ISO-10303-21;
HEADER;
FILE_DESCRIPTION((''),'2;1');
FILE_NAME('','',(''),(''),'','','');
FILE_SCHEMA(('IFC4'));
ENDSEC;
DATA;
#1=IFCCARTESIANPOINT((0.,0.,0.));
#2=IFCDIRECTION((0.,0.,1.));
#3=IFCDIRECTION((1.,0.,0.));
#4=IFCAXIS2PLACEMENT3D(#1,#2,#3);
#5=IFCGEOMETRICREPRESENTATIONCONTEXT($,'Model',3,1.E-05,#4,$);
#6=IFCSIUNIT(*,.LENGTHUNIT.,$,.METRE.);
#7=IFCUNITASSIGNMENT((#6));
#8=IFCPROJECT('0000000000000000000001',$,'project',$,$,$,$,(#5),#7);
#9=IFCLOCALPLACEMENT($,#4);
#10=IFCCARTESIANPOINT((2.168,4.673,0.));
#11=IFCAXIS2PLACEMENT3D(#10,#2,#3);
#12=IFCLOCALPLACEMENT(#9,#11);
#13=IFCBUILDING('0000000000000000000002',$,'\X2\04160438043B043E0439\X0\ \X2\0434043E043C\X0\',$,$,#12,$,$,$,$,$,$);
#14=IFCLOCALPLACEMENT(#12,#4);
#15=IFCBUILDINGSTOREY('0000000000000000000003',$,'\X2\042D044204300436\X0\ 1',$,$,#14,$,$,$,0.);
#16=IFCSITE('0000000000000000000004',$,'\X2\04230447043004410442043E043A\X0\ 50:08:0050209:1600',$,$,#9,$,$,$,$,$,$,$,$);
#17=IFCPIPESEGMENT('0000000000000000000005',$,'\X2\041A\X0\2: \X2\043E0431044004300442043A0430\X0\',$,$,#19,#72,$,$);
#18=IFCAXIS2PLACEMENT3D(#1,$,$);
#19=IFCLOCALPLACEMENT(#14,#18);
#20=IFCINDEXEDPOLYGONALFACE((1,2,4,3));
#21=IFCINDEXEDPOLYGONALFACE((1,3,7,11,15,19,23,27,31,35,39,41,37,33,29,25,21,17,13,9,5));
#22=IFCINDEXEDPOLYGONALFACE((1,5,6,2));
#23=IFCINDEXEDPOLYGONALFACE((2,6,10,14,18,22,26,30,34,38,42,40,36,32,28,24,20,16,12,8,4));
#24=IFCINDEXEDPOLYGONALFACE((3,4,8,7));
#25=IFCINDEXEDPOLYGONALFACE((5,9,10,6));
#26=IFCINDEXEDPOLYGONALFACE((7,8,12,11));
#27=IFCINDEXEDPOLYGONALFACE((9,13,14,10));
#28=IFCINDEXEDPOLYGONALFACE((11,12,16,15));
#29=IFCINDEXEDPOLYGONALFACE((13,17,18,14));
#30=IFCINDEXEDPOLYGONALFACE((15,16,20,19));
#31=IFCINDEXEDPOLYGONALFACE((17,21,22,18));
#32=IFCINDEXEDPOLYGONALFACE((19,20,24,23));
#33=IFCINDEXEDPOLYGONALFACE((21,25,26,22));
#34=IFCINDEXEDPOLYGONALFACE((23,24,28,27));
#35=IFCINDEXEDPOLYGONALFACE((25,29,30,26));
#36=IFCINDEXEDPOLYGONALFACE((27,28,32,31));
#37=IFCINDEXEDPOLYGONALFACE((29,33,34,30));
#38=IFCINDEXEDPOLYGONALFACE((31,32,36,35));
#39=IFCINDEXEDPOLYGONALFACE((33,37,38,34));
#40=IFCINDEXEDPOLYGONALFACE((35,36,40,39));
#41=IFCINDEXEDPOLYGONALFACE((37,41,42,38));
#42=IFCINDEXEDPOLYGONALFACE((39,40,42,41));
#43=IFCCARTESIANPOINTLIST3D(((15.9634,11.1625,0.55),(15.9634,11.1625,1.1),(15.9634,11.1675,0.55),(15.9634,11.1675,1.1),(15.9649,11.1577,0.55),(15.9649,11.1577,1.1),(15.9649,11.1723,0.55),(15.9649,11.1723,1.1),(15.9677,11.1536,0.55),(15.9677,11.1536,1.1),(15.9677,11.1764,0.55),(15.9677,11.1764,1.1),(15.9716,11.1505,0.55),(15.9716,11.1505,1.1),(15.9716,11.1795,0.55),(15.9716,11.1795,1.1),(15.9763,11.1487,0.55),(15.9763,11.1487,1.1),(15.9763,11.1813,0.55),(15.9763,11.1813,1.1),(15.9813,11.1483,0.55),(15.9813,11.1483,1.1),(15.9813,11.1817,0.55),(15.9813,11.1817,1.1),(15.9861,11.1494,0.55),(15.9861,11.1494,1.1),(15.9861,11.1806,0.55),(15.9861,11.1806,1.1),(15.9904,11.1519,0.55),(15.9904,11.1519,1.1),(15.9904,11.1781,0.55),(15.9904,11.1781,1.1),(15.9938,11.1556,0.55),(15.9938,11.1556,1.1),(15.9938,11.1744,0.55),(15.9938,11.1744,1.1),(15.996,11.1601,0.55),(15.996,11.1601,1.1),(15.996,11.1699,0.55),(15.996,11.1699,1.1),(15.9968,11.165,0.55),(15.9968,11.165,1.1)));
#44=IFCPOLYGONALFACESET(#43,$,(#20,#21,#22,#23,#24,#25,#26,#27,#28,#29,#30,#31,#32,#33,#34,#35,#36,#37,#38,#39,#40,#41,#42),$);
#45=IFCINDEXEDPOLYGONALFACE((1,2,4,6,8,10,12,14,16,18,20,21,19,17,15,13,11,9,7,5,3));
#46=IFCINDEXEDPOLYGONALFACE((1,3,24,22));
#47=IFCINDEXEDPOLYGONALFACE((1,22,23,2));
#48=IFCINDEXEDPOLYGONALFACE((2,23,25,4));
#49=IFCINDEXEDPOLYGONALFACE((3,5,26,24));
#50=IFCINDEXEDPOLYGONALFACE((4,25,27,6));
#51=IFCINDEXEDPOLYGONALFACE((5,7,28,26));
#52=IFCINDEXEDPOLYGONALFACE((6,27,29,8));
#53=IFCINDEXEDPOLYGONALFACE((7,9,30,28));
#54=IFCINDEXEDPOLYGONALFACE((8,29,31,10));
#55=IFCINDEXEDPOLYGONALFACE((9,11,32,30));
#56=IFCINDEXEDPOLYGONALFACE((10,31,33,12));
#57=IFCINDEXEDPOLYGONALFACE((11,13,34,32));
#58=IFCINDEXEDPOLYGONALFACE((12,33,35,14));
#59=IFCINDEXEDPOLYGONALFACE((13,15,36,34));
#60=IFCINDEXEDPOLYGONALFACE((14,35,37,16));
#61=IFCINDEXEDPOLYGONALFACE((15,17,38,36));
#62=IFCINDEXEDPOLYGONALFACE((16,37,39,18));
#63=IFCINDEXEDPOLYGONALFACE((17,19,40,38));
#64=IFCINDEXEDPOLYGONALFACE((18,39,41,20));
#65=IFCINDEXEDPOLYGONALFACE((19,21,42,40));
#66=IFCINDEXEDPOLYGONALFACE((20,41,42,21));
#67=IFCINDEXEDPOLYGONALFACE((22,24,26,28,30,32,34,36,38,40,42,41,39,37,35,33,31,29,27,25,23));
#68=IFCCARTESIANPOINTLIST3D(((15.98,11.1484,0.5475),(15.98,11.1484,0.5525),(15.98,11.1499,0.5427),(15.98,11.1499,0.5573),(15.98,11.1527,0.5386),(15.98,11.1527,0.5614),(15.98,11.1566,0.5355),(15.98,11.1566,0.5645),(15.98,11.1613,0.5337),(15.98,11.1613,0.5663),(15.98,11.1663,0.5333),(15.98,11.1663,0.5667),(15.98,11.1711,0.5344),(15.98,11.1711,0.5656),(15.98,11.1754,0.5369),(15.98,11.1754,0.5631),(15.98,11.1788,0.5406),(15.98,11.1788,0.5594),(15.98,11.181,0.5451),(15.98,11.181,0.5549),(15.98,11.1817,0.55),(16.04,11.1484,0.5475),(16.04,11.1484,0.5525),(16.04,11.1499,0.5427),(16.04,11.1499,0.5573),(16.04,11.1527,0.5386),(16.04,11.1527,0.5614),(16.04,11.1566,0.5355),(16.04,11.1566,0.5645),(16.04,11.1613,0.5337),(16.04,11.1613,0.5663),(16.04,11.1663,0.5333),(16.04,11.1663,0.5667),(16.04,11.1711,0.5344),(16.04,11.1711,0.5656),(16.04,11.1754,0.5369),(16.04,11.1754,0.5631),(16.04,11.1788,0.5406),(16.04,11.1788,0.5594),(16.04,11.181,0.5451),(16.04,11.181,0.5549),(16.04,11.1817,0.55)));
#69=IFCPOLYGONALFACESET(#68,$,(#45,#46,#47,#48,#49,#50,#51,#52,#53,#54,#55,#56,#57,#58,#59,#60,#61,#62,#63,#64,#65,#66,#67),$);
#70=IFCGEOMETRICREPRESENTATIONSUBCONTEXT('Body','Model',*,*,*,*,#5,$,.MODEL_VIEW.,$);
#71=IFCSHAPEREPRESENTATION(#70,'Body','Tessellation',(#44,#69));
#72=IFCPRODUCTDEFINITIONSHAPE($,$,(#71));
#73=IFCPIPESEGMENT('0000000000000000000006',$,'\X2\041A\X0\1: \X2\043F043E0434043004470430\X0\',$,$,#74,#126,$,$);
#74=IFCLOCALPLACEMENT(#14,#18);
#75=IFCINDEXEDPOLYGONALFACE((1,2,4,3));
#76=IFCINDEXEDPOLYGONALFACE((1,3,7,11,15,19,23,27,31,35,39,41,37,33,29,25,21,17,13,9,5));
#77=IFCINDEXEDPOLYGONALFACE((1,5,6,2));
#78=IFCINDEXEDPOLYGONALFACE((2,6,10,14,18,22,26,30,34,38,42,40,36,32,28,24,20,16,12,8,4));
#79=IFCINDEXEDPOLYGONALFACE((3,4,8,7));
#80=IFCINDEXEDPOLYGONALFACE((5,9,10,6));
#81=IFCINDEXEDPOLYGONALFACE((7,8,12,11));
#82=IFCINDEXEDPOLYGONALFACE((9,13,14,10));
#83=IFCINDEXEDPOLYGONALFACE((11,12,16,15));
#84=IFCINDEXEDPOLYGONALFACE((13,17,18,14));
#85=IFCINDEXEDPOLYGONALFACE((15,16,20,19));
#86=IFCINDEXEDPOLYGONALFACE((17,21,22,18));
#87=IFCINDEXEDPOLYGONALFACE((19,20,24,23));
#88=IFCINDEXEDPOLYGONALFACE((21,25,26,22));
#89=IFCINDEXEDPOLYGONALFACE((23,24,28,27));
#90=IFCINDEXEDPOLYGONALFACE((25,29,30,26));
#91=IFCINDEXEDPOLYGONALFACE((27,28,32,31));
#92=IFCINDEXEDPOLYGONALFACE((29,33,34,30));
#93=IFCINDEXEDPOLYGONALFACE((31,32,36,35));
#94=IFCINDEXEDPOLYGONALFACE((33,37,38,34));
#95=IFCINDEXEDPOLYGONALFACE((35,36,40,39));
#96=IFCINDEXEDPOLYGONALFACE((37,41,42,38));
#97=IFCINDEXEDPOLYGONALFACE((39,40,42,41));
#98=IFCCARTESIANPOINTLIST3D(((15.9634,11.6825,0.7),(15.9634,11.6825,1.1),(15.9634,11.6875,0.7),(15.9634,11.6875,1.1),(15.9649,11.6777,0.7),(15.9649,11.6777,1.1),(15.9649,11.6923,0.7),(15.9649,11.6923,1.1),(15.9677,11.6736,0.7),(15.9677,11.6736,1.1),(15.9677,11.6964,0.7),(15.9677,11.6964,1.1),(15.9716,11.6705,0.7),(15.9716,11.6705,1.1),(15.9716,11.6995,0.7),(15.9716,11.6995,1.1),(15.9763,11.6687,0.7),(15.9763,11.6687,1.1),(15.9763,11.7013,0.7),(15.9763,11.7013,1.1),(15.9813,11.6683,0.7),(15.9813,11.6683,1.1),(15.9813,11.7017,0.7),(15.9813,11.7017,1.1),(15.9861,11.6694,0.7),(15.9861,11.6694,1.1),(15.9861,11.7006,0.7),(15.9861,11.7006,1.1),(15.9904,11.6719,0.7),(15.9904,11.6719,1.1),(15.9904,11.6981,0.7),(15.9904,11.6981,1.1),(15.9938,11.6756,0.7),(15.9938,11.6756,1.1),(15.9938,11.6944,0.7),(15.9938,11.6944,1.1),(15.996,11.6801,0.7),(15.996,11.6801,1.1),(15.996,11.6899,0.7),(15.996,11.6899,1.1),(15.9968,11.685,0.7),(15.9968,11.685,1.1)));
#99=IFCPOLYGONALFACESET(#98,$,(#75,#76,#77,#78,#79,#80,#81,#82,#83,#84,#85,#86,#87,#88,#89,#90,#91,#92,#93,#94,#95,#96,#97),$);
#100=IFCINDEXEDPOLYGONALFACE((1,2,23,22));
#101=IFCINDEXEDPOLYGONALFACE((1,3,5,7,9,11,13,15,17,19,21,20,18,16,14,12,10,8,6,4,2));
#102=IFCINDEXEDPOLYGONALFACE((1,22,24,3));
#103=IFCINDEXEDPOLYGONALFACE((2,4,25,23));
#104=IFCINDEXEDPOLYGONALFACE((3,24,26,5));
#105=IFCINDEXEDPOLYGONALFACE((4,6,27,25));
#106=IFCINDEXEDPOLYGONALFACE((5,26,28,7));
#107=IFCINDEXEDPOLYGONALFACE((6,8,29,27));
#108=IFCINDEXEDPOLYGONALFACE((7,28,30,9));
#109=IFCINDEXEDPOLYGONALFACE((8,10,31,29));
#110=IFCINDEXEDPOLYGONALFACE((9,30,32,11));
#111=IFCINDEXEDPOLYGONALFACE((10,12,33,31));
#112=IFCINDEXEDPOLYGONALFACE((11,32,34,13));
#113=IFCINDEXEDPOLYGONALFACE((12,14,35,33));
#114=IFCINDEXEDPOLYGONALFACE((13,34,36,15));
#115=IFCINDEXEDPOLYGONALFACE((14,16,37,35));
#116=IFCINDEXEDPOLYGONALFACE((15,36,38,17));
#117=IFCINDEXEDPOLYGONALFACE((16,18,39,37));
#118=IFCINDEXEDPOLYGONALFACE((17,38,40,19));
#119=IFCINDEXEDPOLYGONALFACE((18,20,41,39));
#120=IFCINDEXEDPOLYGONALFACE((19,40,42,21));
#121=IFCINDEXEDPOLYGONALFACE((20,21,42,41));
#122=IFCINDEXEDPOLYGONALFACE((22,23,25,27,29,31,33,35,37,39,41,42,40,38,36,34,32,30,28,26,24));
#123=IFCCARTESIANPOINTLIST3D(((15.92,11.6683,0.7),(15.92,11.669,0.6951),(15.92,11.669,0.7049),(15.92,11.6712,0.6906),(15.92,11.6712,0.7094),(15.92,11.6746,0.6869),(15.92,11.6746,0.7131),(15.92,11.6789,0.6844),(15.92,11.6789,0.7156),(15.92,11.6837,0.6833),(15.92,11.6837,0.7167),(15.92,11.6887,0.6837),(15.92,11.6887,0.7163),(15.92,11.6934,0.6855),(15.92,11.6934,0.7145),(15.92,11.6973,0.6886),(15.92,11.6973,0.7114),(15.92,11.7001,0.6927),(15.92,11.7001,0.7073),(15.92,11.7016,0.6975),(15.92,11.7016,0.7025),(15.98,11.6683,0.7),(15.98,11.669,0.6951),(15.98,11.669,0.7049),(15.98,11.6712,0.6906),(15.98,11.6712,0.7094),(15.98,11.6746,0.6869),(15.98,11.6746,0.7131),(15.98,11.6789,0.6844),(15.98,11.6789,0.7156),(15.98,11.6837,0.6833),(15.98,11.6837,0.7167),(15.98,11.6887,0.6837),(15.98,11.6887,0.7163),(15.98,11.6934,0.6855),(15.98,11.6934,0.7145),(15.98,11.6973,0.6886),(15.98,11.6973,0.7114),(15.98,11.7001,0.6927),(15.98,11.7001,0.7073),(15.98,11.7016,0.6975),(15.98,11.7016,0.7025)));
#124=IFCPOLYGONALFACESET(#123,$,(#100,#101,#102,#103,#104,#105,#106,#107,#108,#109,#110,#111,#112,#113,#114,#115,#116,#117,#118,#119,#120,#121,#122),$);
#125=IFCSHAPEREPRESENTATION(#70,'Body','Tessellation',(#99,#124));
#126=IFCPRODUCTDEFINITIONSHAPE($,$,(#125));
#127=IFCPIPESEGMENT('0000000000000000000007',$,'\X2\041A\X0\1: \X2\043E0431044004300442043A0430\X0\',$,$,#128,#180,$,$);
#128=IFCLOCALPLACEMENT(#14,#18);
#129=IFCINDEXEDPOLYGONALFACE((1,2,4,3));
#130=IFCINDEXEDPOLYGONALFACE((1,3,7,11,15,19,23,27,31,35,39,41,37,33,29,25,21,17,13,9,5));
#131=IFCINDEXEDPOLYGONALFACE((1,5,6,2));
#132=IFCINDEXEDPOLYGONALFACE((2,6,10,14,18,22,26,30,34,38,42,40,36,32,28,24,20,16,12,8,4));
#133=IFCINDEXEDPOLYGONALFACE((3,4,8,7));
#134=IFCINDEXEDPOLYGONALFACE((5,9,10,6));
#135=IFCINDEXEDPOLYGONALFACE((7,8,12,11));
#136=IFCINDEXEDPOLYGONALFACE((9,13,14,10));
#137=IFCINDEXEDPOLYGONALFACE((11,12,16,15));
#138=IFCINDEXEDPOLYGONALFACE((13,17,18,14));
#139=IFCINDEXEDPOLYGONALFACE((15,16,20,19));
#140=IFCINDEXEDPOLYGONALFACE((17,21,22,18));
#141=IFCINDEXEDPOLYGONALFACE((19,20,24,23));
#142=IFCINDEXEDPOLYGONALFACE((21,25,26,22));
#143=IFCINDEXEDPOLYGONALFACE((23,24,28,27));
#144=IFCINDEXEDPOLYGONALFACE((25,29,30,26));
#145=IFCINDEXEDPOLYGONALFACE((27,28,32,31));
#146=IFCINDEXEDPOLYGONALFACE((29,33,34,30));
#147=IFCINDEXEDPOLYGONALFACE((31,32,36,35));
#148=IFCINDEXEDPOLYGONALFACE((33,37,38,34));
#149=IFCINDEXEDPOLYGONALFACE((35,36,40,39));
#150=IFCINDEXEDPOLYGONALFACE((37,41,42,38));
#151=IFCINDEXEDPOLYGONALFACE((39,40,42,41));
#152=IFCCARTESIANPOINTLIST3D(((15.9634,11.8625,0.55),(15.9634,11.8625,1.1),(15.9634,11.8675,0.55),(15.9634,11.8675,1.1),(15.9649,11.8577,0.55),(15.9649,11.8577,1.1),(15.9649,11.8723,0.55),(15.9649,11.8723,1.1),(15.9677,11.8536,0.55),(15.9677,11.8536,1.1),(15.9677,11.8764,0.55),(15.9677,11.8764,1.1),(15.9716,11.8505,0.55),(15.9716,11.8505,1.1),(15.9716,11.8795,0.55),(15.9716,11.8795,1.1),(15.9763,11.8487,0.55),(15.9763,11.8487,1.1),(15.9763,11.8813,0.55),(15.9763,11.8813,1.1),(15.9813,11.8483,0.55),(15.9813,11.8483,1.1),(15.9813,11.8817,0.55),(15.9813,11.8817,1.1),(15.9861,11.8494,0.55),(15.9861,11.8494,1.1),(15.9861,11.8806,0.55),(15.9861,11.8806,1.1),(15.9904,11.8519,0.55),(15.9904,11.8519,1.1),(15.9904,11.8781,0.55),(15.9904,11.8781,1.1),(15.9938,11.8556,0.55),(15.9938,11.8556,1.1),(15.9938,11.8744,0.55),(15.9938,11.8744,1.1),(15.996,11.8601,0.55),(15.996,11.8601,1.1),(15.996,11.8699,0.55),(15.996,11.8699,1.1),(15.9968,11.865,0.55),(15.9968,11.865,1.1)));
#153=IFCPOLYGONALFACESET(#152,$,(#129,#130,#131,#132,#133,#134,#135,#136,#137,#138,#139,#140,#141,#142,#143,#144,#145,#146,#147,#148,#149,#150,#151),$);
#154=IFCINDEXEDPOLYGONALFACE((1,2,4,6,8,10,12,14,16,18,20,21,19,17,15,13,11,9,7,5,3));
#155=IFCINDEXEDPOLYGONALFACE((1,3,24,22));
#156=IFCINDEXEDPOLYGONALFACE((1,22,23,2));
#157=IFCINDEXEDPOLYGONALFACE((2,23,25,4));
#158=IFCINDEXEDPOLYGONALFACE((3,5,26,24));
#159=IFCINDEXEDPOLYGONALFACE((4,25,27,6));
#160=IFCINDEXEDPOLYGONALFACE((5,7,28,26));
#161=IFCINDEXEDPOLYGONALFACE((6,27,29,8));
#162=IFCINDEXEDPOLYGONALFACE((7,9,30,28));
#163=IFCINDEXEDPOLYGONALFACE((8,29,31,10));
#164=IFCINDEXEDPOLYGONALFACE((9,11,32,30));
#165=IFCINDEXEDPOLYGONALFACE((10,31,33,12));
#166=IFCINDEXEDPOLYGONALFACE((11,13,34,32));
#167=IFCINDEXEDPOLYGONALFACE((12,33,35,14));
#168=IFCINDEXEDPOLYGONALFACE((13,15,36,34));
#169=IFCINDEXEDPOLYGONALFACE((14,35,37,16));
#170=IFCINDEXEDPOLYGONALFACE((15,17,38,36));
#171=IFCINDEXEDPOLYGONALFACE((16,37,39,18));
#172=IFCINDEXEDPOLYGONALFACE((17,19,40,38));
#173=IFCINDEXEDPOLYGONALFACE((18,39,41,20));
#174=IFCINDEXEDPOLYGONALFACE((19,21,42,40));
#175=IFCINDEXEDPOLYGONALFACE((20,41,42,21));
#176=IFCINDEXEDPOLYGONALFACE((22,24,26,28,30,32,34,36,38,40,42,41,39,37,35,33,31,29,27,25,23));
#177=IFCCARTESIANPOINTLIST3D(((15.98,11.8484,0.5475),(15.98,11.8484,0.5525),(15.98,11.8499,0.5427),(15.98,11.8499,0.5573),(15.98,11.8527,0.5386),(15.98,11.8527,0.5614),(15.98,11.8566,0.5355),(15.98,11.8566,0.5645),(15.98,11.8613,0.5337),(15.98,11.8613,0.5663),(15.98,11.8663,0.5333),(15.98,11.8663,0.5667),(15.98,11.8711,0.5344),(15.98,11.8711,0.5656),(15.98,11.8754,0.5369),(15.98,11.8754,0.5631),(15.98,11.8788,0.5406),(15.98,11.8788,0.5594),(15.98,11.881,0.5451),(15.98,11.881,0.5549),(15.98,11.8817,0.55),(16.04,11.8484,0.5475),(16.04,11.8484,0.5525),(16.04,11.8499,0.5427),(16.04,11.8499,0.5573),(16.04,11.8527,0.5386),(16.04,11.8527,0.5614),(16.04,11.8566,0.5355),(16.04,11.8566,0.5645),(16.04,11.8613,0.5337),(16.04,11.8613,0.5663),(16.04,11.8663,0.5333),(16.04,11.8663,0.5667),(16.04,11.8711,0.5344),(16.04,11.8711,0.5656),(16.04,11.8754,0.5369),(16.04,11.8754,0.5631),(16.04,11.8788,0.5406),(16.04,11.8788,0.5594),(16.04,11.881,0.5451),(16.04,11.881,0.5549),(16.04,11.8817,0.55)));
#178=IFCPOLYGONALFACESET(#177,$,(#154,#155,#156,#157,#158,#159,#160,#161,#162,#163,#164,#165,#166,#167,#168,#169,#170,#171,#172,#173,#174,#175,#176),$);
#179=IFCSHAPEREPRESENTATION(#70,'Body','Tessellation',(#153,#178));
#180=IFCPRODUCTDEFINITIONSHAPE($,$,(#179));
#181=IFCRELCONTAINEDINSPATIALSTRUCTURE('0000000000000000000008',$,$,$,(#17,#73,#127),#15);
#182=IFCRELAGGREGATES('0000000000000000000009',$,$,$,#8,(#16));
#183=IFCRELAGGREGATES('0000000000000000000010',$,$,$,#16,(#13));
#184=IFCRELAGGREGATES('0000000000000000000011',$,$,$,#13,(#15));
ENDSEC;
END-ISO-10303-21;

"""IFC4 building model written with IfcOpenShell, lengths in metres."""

from ifc_helpers import new_model, si_unit, frame, origin_with_axes, origin_2d, place, context, subcontext, project, spatial, circle, extrude, element, save


model = new_model("IFC4")

# Units and contexts
model_context = context("Model", 3, precision=1e-05, world=origin_with_axes())
body_context = subcontext(model_context, "Body", "Model", "MODEL_VIEW")
ifc_project = project(units=[si_unit("LENGTHUNIT", "METRE")], contexts=[model_context])

# Site, building, storey
site_placement = place(None, origin_with_axes())
site = spatial("IfcSite", under=ifc_project, at=site_placement, Name="Участок 50:08:0050209:1600")
building_placement = place(site_placement, frame((2.168, 4.673, 0.0), z_axis=(0.0, 0.0, 1.0), x_axis=(1.0, 0.0, 0.0)))
building = spatial("IfcBuilding", under=site, at=building_placement, Name="Жилой дом")
storey_placement = place(building_placement, origin_with_axes())
storey = spatial("IfcBuildingStorey", under=building, at=storey_placement, Name="Этаж 1", Elevation=0.0)

# Pipe segments
pipe_segment_1_placement = place(storey_placement, origin_with_axes())
element("IfcPipeSegment", 1, at=pipe_segment_1_placement, inside=storey, Name="К2: обратка", context=body_context, shape_type="SweptSolid", body=[
    extrude(circle(Radius=0.0168, at=origin_2d()), frame((15.98, 11.165, 1.1), z_axis=(0.0, 0.0, -1.0), x_axis=(1.0, 0.0, 0.0)), (0.0, 0.0, 1.0), 0.55),
    extrude(circle(Radius=0.0168, at=origin_2d()), frame((15.98, 11.165, 0.55), z_axis=(1.0, 0.0, 0.0), x_axis=(0.0, 1.0, 0.0)), (0.0, 0.0, 1.0), 0.06),
])
pipe_segment_2_placement = place(storey_placement, origin_with_axes())
element("IfcPipeSegment", 2, at=pipe_segment_2_placement, inside=storey, Name="К1: подача", context=body_context, shape_type="SweptSolid", body=[
    extrude(circle(Radius=0.0168, at=origin_2d()), frame((15.98, 11.685, 1.1), z_axis=(0.0, 0.0, -1.0), x_axis=(1.0, 0.0, 0.0)), (0.0, 0.0, 1.0), 0.4),
    extrude(circle(Radius=0.0168, at=origin_2d()), frame((15.98, 11.685, 0.7), z_axis=(-1.0, 0.0, 0.0), x_axis=(0.0, -1.0, 0.0)), (0.0, 0.0, 1.0), 0.06),
])
pipe_segment_3_placement = place(storey_placement, origin_with_axes())
element("IfcPipeSegment", 3, at=pipe_segment_3_placement, inside=storey, Name="К1: обратка", context=body_context, shape_type="SweptSolid", body=[
    extrude(circle(Radius=0.0168, at=origin_2d()), frame((15.98, 11.865, 1.1), z_axis=(0.0, 0.0, -1.0), x_axis=(1.0, 0.0, 0.0)), (0.0, 0.0, 1.0), 0.55),
    extrude(circle(Radius=0.0168, at=origin_2d()), frame((15.98, 11.865, 0.55), z_axis=(1.0, 0.0, 0.0), x_axis=(0.0, 1.0, 0.0)), (0.0, 0.0, 1.0), 0.06),
])

save(model, "model.ifc")
